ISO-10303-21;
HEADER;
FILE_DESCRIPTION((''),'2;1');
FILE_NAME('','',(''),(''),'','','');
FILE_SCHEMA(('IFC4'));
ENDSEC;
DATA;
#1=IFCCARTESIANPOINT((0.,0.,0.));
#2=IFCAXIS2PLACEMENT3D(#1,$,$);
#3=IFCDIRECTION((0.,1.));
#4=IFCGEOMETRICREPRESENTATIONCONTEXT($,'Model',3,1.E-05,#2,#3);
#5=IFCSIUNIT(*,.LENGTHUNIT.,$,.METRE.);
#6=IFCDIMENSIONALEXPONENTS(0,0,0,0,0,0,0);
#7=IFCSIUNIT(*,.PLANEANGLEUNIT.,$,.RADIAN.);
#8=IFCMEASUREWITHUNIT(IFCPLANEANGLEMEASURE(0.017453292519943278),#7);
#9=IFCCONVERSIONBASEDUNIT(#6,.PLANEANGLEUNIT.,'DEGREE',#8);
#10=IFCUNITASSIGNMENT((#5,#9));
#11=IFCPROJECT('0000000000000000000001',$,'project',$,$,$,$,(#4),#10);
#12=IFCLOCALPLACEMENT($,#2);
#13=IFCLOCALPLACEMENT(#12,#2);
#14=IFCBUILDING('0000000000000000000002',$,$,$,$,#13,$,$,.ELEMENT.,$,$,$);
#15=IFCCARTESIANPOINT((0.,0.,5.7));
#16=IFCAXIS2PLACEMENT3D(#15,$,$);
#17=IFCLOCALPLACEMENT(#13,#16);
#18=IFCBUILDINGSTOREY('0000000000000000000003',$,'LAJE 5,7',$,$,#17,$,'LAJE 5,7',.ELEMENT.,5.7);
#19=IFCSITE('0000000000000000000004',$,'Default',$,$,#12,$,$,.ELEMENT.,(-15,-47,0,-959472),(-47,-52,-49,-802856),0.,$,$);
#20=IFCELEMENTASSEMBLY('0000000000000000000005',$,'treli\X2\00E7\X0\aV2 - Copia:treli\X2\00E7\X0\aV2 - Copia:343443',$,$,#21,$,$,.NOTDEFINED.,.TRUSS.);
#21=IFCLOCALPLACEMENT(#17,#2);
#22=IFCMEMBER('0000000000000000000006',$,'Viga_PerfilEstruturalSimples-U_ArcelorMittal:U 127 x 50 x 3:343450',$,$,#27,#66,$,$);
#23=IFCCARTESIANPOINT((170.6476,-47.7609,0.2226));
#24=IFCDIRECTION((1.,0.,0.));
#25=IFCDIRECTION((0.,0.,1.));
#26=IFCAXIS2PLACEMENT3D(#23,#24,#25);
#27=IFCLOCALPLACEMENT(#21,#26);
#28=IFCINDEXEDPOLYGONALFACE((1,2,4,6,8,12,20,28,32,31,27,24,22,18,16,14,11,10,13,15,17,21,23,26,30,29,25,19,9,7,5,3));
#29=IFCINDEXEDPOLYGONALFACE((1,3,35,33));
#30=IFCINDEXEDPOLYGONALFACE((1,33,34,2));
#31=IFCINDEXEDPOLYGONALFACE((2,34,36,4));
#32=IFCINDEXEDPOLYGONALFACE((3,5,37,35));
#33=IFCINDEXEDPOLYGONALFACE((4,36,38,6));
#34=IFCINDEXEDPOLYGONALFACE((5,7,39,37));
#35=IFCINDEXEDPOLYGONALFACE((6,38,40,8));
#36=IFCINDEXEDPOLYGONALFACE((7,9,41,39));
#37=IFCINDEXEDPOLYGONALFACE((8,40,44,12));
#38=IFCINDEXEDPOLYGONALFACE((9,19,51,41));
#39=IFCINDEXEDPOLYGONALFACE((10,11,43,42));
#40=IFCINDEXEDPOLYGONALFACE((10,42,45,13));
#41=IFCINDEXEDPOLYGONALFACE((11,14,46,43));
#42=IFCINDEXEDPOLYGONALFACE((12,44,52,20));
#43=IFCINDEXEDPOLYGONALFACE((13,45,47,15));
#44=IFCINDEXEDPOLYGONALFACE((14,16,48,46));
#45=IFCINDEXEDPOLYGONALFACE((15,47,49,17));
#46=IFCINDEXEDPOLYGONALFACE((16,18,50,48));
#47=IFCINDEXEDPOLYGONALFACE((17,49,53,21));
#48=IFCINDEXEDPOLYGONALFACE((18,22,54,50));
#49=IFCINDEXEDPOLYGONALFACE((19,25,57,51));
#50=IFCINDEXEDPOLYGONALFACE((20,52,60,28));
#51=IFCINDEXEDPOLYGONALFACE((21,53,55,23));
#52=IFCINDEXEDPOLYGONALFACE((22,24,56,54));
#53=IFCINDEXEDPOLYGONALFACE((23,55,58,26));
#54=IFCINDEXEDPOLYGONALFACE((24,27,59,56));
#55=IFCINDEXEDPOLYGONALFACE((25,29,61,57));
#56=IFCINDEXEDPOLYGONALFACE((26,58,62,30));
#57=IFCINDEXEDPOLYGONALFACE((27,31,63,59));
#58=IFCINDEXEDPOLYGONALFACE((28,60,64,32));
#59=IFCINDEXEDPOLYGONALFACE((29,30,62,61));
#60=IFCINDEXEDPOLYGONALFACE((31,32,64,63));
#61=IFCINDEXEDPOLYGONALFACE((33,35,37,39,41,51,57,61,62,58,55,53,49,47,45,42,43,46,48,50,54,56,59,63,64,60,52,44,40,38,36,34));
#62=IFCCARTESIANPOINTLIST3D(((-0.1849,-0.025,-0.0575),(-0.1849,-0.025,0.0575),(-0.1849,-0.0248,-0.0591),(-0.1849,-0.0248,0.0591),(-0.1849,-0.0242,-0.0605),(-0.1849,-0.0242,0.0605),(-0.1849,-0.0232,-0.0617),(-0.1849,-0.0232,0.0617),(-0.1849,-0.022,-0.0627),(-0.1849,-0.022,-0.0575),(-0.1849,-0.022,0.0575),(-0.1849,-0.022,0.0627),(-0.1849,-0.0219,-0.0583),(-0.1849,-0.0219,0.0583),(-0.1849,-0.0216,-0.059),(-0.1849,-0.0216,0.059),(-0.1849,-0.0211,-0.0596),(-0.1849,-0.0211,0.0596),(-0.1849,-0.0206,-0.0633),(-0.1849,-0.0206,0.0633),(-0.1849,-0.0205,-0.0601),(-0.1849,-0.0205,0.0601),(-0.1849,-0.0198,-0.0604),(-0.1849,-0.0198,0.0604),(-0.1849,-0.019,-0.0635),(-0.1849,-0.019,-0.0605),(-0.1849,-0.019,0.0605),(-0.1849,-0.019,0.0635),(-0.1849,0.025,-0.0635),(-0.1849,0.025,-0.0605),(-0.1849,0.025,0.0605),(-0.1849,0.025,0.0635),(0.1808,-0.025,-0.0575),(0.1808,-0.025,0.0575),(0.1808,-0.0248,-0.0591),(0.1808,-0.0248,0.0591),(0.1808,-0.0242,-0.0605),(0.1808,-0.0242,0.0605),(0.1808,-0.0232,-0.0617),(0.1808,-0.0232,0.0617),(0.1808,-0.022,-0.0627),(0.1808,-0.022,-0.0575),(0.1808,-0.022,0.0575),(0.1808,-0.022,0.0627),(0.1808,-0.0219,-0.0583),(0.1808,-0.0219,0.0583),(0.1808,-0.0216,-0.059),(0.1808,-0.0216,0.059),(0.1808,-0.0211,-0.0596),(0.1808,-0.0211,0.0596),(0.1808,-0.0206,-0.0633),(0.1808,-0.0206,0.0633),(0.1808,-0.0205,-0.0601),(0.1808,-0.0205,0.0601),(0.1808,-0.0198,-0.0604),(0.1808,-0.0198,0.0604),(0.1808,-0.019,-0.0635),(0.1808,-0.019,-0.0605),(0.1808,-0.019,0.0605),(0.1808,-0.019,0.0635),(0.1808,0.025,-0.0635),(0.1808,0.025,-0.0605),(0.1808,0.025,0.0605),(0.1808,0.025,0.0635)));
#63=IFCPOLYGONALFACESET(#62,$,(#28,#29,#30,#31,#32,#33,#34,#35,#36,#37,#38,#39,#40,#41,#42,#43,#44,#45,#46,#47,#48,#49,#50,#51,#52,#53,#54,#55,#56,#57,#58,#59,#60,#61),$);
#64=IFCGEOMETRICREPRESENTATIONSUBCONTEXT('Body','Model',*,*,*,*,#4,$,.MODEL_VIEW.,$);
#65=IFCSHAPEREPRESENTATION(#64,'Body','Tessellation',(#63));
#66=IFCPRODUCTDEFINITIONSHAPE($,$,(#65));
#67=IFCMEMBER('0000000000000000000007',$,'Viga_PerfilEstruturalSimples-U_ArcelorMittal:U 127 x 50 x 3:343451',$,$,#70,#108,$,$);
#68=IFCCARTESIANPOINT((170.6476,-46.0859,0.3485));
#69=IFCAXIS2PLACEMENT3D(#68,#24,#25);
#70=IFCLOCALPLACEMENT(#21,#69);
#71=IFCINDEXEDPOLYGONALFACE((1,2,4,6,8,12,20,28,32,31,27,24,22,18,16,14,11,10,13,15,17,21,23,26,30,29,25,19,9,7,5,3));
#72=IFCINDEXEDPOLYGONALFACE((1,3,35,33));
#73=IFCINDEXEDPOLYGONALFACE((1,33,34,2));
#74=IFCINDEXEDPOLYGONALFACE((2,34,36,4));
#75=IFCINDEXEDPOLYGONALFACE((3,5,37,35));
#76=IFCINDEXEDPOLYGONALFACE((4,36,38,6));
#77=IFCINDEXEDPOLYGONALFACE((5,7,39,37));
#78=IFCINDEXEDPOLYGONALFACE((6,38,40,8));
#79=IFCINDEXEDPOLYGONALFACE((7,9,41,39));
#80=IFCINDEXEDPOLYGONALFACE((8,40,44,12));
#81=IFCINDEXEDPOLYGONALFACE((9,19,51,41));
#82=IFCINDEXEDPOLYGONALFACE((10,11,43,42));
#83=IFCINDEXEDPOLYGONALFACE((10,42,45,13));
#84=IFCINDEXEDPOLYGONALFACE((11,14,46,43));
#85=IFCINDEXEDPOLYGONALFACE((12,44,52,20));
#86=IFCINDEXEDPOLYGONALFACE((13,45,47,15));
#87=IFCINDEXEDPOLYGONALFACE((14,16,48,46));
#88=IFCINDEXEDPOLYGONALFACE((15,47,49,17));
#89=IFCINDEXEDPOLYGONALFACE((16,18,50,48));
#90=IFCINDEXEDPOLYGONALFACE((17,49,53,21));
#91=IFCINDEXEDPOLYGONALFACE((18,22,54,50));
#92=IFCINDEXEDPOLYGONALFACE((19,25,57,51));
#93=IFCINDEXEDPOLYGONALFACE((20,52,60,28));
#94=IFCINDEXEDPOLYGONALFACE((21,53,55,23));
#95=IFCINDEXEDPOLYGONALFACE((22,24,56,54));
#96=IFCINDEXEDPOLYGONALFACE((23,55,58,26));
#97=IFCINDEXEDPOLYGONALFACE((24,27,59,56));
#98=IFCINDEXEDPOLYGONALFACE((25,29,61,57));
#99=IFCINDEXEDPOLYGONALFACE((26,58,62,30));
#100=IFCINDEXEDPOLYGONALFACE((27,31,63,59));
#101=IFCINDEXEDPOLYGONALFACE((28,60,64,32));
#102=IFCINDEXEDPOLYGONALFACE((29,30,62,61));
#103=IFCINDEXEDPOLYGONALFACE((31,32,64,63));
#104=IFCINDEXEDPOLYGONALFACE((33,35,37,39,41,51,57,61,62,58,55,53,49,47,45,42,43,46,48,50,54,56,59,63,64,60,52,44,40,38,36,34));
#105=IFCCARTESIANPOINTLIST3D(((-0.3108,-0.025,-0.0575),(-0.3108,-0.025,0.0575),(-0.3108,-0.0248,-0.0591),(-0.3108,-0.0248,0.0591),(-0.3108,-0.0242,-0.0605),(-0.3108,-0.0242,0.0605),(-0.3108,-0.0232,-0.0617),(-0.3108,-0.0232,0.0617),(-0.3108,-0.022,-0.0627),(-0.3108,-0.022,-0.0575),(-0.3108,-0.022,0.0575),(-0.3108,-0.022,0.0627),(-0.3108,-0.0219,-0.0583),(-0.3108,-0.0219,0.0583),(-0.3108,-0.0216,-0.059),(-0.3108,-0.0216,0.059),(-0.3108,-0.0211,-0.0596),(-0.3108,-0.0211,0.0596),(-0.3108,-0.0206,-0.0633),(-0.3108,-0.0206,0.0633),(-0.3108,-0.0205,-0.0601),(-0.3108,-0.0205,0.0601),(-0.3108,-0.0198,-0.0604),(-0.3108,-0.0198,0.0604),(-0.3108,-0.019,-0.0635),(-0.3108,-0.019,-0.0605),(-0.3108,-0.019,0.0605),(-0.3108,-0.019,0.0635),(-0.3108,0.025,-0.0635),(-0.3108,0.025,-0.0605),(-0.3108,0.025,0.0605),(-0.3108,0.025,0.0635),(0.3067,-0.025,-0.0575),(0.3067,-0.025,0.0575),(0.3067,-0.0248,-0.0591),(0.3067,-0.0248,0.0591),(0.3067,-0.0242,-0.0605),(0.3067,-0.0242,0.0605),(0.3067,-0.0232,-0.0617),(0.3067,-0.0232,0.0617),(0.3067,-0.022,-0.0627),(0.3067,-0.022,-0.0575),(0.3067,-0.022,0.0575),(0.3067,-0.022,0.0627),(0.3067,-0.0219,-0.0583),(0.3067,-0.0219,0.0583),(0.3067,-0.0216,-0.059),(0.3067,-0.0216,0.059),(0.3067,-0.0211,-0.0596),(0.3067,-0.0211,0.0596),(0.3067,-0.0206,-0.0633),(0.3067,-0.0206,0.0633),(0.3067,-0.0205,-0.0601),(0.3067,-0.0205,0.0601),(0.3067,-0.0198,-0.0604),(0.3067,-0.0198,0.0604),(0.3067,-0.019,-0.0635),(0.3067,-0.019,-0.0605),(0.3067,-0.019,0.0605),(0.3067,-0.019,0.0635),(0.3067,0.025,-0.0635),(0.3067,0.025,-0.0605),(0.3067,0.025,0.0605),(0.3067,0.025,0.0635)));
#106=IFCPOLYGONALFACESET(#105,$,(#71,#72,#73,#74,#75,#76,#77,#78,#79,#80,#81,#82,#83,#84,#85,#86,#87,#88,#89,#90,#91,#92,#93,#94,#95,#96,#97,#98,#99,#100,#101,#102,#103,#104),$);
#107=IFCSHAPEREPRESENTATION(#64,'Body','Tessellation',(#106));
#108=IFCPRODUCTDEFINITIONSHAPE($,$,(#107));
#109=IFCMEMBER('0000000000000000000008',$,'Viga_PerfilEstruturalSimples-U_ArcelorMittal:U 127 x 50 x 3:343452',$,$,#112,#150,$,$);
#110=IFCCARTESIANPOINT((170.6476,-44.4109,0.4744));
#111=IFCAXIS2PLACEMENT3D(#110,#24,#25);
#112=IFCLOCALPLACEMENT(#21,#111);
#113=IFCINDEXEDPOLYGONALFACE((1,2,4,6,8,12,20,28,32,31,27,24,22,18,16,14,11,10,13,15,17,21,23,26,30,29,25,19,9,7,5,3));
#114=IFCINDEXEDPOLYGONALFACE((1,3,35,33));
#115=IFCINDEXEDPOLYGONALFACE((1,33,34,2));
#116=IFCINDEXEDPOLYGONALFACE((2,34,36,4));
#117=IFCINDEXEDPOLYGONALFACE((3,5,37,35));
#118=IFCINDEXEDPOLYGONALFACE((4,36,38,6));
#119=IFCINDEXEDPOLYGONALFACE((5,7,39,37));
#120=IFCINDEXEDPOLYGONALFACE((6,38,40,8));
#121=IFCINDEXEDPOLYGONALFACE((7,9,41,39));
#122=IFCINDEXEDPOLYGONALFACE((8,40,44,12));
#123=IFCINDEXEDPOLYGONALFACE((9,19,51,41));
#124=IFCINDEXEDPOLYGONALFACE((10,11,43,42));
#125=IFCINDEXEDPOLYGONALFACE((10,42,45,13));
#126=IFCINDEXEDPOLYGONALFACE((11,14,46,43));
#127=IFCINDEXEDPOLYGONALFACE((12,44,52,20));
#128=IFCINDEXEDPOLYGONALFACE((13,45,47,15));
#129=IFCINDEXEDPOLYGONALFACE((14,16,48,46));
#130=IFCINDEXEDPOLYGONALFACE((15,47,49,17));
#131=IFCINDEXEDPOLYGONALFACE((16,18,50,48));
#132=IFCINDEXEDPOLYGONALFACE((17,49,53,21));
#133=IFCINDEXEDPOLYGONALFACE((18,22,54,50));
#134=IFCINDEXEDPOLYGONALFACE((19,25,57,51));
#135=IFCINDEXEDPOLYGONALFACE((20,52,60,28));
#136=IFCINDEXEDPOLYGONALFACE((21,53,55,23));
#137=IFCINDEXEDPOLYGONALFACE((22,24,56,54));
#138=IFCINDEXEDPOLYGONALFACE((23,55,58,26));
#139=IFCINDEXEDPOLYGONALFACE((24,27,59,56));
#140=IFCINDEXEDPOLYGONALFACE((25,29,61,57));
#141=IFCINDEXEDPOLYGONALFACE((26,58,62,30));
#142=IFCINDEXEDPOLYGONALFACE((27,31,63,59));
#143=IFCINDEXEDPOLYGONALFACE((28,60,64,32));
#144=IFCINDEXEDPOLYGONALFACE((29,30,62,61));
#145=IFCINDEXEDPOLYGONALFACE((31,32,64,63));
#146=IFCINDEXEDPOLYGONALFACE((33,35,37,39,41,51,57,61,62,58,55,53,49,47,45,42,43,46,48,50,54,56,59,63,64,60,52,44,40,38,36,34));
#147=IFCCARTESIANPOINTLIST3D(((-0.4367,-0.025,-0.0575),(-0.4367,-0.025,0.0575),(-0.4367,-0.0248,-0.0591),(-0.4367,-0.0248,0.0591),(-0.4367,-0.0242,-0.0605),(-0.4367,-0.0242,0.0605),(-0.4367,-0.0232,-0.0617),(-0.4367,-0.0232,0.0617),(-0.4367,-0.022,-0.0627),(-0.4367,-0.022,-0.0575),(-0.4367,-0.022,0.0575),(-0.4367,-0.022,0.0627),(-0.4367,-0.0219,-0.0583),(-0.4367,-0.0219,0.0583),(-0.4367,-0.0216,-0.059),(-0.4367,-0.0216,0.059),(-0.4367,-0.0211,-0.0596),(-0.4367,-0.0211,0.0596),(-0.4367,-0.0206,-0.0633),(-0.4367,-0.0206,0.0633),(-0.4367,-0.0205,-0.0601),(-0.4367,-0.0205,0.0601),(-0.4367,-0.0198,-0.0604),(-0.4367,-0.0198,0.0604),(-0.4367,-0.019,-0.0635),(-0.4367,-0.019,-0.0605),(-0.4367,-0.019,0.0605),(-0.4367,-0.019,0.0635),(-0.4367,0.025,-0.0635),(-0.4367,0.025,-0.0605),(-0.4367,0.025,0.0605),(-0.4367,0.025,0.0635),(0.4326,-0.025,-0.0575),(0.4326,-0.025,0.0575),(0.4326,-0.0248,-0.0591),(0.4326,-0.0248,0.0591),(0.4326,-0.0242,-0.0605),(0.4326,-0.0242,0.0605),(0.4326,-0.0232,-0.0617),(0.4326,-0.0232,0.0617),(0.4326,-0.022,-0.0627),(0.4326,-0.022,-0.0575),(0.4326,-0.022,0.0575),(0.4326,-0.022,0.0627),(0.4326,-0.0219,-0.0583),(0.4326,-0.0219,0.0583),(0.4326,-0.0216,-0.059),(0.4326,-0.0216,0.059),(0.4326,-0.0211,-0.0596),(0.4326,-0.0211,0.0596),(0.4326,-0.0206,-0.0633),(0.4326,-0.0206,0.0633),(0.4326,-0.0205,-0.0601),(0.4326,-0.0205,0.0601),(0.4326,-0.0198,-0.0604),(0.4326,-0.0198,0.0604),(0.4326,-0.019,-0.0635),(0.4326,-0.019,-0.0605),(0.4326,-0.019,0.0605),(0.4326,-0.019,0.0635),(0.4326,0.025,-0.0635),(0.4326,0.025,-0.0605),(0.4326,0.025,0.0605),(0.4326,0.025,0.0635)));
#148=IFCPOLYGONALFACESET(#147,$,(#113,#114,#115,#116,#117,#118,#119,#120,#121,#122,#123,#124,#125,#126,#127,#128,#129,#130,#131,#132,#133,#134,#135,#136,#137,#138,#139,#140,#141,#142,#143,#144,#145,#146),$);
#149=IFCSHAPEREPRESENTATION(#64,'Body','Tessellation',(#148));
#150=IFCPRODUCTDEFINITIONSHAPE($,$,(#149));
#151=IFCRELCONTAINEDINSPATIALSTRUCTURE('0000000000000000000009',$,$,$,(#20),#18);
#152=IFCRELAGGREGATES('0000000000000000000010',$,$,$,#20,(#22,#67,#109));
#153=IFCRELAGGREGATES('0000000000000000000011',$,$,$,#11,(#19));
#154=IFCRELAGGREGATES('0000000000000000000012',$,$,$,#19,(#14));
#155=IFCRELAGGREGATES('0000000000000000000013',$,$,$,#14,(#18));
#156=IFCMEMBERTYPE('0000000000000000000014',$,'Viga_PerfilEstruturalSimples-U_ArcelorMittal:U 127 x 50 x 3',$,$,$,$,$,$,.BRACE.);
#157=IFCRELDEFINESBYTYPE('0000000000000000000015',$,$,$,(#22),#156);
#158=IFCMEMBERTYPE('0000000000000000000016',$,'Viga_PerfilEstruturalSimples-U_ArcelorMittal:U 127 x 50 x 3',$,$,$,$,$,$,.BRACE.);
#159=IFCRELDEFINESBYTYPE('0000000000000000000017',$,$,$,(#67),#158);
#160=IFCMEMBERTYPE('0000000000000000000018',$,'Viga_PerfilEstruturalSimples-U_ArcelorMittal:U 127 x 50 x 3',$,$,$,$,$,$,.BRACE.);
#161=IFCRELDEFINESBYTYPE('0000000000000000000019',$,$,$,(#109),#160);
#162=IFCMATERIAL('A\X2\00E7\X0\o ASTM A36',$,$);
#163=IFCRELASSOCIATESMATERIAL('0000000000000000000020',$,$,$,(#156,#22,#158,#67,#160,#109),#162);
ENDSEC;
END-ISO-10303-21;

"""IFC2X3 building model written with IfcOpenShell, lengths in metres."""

from ifc_helpers import new_model, entity, si_unit, converted_unit, direction, frame, frame_2d, origin, place, context, subcontext, project, spatial, polyline, circle_curve, parameter, trimmed, segment, composite_curve, outline, extrude, source, transform, mapped, material, type_object, type_shapes, element, aggregate, save


model = new_model("IFC2X3")

# Units and contexts
model_context = context("Model", 3, precision=1e-05, world=origin(), true_north=direction((0.0, 1.0)))
body_context = subcontext(model_context, "Body", "Model", "MODEL_VIEW")
ifc_project = project(units=[si_unit("LENGTHUNIT", "METRE"), converted_unit("PLANEANGLEUNIT", "DEGREE", entity("IfcPlaneAngleMeasure", 0.017453292519943278), si_unit("PLANEANGLEUNIT", "RADIAN"), dimensions=[0, 0, 0, 0, 0, 0, 0])], contexts=[model_context])

# Site, building, storey
site_placement = place(None, origin())
site = spatial("IfcSite", under=ifc_project, at=site_placement, Name="Default", CompositionType="ELEMENT", RefLatitude=(-15, -47, 0, -959472), RefLongitude=(-47, -52, -49, -802856), RefElevation=0.0)
building_placement = place(site_placement, origin())
building = spatial("IfcBuilding", under=site, at=building_placement, CompositionType="ELEMENT")
storey_placement = place(building_placement, frame((0.0, 0.0, 5.7)))
storey = spatial("IfcBuildingStorey", under=building, at=storey_placement, Name="LAJE 5,7", LongName="LAJE 5,7", CompositionType="ELEMENT", Elevation=5.7)

# Element assembly
ifc_material = material(Name="Aço ASTM A36")
assembly_1_placement = place(storey_placement, origin())
assembly_1 = element("IfcElementAssembly", 1, at=assembly_1_placement, inside=storey, Name="treliçaV2 - Copia:treliçaV2 - Copia:343443", AssemblyPlace="NOTDEFINED", PredefinedType="TRUSS")

# Members
member_type_1 = type_object("IfcMemberType", Name="Viga_PerfilEstruturalSimples-U_ArcelorMittal:U 127 x 50 x 3", PredefinedType="BRACE", material=ifc_material)
shared_shape_1 = source(origin(), body_context, "Body", "SweptSolid", [
    extrude(outline(composite_curve([segment(polyline([(-0.0575, -0.0192), (0.0575, -0.0192)]), True, "CONTINUOUS"), segment(trimmed(circle_curve(frame_2d((0.0575, -0.0132), x_axis=(0.0, 1.0)), 0.006), [parameter(180.0)], [parameter(270.0)], True, "PARAMETER"), True, "CONTINUOUS"), segment(polyline([(0.0635, -0.0132), (0.0635, 0.0308)]), True, "CONTINUOUS"), segment(polyline([(0.0635, 0.0308), (0.0605, 0.0308)]), True, "CONTINUOUS"), segment(polyline([(0.0605, 0.0308), (0.0605, -0.0132)]), True, "CONTINUOUS"), segment(trimmed(circle_curve(frame_2d((0.0575, -0.0132), x_axis=(0.0, 1.0)), 0.003), [parameter(180.0)], [parameter(270.0)], True, "PARAMETER"), False, "CONTINUOUS"), segment(polyline([(0.0575, -0.0162), (-0.0575, -0.0162)]), True, "CONTINUOUS"), segment(trimmed(circle_curve(frame_2d((-0.0575, -0.0132), x_axis=(0.0, 1.0)), 0.003), [parameter(90.0)], [parameter(180.0)], True, "PARAMETER"), False, "CONTINUOUS"), segment(polyline([(-0.0605, -0.0132), (-0.0605, 0.0308)]), True, "CONTINUOUS"), segment(polyline([(-0.0605, 0.0308), (-0.0635, 0.0308)]), True, "CONTINUOUS"), segment(polyline([(-0.0635, 0.0308), (-0.0635, -0.0132)]), True, "CONTINUOUS"), segment(trimmed(circle_curve(frame_2d((-0.0575, -0.0132), x_axis=(0.0, 1.0)), 0.006), [parameter(90.0)], [parameter(180.0)], True, "PARAMETER"), True, "CONTINUOUS")], self_intersect=False)), frame((-0.1849, -0.0058, 0.0), z_axis=(1.0, 0.0, 0.0), x_axis=(0.0, 0.0, -1.0)), (0.0, 0.0, 1.0), 0.3657),
])
type_shapes(member_type_1, [shared_shape_1])
member_1_placement = place(assembly_1_placement, frame((170.6476, -47.7609, 0.2226), z_axis=(1.0, 0.0, 0.0), x_axis=(0.0, 0.0, 1.0)))
member_1 = element("IfcMember", 2, at=member_1_placement, type_object=member_type_1, material=ifc_material, Name="Viga_PerfilEstruturalSimples-U_ArcelorMittal:U 127 x 50 x 3:343450", context=body_context, shape_type="MappedRepresentation", body=[
    mapped(shared_shape_1, transform((0.0, 0.0, 0.0), scale=1.0)),
])
member_type_2 = type_object("IfcMemberType", Name="Viga_PerfilEstruturalSimples-U_ArcelorMittal:U 127 x 50 x 3", PredefinedType="BRACE", material=ifc_material)
shared_shape_2 = source(origin(), body_context, "Body", "SweptSolid", [
    extrude(outline(composite_curve([segment(polyline([(-0.0575, -0.0192), (0.0575, -0.0192)]), True, "CONTINUOUS"), segment(trimmed(circle_curve(frame_2d((0.0575, -0.0132), x_axis=(0.0, 1.0)), 0.006), [parameter(180.0)], [parameter(270.0)], True, "PARAMETER"), True, "CONTINUOUS"), segment(polyline([(0.0635, -0.0132), (0.0635, 0.0308)]), True, "CONTINUOUS"), segment(polyline([(0.0635, 0.0308), (0.0605, 0.0308)]), True, "CONTINUOUS"), segment(polyline([(0.0605, 0.0308), (0.0605, -0.0132)]), True, "CONTINUOUS"), segment(trimmed(circle_curve(frame_2d((0.0575, -0.0132), x_axis=(0.0, 1.0)), 0.003), [parameter(180.0)], [parameter(270.0)], True, "PARAMETER"), False, "CONTINUOUS"), segment(polyline([(0.0575, -0.0162), (-0.0575, -0.0162)]), True, "CONTINUOUS"), segment(trimmed(circle_curve(frame_2d((-0.0575, -0.0132), x_axis=(0.0, 1.0)), 0.003), [parameter(90.0)], [parameter(180.0)], True, "PARAMETER"), False, "CONTINUOUS"), segment(polyline([(-0.0605, -0.0132), (-0.0605, 0.0308)]), True, "CONTINUOUS"), segment(polyline([(-0.0605, 0.0308), (-0.0635, 0.0308)]), True, "CONTINUOUS"), segment(polyline([(-0.0635, 0.0308), (-0.0635, -0.0132)]), True, "CONTINUOUS"), segment(trimmed(circle_curve(frame_2d((-0.0575, -0.0132), x_axis=(0.0, 1.0)), 0.006), [parameter(90.0)], [parameter(180.0)], True, "PARAMETER"), True, "CONTINUOUS")], self_intersect=False)), frame((-0.3108, -0.0058, 0.0), z_axis=(1.0, 0.0, 0.0), x_axis=(0.0, 0.0, -1.0)), (0.0, 0.0, 1.0), 0.6175),
])
type_shapes(member_type_2, [shared_shape_2])
member_2_placement = place(assembly_1_placement, frame((170.6476, -46.0859, 0.3485), z_axis=(1.0, 0.0, 0.0), x_axis=(0.0, 0.0, 1.0)))
member_2 = element("IfcMember", 3, at=member_2_placement, type_object=member_type_2, material=ifc_material, Name="Viga_PerfilEstruturalSimples-U_ArcelorMittal:U 127 x 50 x 3:343451", context=body_context, shape_type="MappedRepresentation", body=[
    mapped(shared_shape_2, transform((0.0, 0.0, 0.0), scale=1.0)),
])
member_type_3 = type_object("IfcMemberType", Name="Viga_PerfilEstruturalSimples-U_ArcelorMittal:U 127 x 50 x 3", PredefinedType="BRACE", material=ifc_material)
shared_shape_3 = source(origin(), body_context, "Body", "SweptSolid", [
    extrude(outline(composite_curve([segment(polyline([(-0.0575, -0.0192), (0.0575, -0.0192)]), True, "CONTINUOUS"), segment(trimmed(circle_curve(frame_2d((0.0575, -0.0132), x_axis=(0.0, 1.0)), 0.006), [parameter(180.0)], [parameter(270.0)], True, "PARAMETER"), True, "CONTINUOUS"), segment(polyline([(0.0635, -0.0132), (0.0635, 0.0308)]), True, "CONTINUOUS"), segment(polyline([(0.0635, 0.0308), (0.0605, 0.0308)]), True, "CONTINUOUS"), segment(polyline([(0.0605, 0.0308), (0.0605, -0.0132)]), True, "CONTINUOUS"), segment(trimmed(circle_curve(frame_2d((0.0575, -0.0132), x_axis=(0.0, 1.0)), 0.003), [parameter(180.0)], [parameter(270.0)], True, "PARAMETER"), False, "CONTINUOUS"), segment(polyline([(0.0575, -0.0162), (-0.0575, -0.0162)]), True, "CONTINUOUS"), segment(trimmed(circle_curve(frame_2d((-0.0575, -0.0132), x_axis=(0.0, 1.0)), 0.003), [parameter(90.0)], [parameter(180.0)], True, "PARAMETER"), False, "CONTINUOUS"), segment(polyline([(-0.0605, -0.0132), (-0.0605, 0.0308)]), True, "CONTINUOUS"), segment(polyline([(-0.0605, 0.0308), (-0.0635, 0.0308)]), True, "CONTINUOUS"), segment(polyline([(-0.0635, 0.0308), (-0.0635, -0.0132)]), True, "CONTINUOUS"), segment(trimmed(circle_curve(frame_2d((-0.0575, -0.0132), x_axis=(0.0, 1.0)), 0.006), [parameter(90.0)], [parameter(180.0)], True, "PARAMETER"), True, "CONTINUOUS")], self_intersect=False)), frame((-0.4367, -0.0058, 0.0), z_axis=(1.0, 0.0, 0.0), x_axis=(0.0, 0.0, -1.0)), (0.0, 0.0, 1.0), 0.8693),
])
type_shapes(member_type_3, [shared_shape_3])
member_3_placement = place(assembly_1_placement, frame((170.6476, -44.4109, 0.4744), z_axis=(1.0, 0.0, 0.0), x_axis=(0.0, 0.0, 1.0)))
member_3 = element("IfcMember", 4, at=member_3_placement, type_object=member_type_3, material=ifc_material, Name="Viga_PerfilEstruturalSimples-U_ArcelorMittal:U 127 x 50 x 3:343452", context=body_context, shape_type="MappedRepresentation", body=[
    mapped(shared_shape_3, transform((0.0, 0.0, 0.0), scale=1.0)),
])
aggregate(assembly_1, [member_1, member_2, member_3])

save(model, "model.ifc")
